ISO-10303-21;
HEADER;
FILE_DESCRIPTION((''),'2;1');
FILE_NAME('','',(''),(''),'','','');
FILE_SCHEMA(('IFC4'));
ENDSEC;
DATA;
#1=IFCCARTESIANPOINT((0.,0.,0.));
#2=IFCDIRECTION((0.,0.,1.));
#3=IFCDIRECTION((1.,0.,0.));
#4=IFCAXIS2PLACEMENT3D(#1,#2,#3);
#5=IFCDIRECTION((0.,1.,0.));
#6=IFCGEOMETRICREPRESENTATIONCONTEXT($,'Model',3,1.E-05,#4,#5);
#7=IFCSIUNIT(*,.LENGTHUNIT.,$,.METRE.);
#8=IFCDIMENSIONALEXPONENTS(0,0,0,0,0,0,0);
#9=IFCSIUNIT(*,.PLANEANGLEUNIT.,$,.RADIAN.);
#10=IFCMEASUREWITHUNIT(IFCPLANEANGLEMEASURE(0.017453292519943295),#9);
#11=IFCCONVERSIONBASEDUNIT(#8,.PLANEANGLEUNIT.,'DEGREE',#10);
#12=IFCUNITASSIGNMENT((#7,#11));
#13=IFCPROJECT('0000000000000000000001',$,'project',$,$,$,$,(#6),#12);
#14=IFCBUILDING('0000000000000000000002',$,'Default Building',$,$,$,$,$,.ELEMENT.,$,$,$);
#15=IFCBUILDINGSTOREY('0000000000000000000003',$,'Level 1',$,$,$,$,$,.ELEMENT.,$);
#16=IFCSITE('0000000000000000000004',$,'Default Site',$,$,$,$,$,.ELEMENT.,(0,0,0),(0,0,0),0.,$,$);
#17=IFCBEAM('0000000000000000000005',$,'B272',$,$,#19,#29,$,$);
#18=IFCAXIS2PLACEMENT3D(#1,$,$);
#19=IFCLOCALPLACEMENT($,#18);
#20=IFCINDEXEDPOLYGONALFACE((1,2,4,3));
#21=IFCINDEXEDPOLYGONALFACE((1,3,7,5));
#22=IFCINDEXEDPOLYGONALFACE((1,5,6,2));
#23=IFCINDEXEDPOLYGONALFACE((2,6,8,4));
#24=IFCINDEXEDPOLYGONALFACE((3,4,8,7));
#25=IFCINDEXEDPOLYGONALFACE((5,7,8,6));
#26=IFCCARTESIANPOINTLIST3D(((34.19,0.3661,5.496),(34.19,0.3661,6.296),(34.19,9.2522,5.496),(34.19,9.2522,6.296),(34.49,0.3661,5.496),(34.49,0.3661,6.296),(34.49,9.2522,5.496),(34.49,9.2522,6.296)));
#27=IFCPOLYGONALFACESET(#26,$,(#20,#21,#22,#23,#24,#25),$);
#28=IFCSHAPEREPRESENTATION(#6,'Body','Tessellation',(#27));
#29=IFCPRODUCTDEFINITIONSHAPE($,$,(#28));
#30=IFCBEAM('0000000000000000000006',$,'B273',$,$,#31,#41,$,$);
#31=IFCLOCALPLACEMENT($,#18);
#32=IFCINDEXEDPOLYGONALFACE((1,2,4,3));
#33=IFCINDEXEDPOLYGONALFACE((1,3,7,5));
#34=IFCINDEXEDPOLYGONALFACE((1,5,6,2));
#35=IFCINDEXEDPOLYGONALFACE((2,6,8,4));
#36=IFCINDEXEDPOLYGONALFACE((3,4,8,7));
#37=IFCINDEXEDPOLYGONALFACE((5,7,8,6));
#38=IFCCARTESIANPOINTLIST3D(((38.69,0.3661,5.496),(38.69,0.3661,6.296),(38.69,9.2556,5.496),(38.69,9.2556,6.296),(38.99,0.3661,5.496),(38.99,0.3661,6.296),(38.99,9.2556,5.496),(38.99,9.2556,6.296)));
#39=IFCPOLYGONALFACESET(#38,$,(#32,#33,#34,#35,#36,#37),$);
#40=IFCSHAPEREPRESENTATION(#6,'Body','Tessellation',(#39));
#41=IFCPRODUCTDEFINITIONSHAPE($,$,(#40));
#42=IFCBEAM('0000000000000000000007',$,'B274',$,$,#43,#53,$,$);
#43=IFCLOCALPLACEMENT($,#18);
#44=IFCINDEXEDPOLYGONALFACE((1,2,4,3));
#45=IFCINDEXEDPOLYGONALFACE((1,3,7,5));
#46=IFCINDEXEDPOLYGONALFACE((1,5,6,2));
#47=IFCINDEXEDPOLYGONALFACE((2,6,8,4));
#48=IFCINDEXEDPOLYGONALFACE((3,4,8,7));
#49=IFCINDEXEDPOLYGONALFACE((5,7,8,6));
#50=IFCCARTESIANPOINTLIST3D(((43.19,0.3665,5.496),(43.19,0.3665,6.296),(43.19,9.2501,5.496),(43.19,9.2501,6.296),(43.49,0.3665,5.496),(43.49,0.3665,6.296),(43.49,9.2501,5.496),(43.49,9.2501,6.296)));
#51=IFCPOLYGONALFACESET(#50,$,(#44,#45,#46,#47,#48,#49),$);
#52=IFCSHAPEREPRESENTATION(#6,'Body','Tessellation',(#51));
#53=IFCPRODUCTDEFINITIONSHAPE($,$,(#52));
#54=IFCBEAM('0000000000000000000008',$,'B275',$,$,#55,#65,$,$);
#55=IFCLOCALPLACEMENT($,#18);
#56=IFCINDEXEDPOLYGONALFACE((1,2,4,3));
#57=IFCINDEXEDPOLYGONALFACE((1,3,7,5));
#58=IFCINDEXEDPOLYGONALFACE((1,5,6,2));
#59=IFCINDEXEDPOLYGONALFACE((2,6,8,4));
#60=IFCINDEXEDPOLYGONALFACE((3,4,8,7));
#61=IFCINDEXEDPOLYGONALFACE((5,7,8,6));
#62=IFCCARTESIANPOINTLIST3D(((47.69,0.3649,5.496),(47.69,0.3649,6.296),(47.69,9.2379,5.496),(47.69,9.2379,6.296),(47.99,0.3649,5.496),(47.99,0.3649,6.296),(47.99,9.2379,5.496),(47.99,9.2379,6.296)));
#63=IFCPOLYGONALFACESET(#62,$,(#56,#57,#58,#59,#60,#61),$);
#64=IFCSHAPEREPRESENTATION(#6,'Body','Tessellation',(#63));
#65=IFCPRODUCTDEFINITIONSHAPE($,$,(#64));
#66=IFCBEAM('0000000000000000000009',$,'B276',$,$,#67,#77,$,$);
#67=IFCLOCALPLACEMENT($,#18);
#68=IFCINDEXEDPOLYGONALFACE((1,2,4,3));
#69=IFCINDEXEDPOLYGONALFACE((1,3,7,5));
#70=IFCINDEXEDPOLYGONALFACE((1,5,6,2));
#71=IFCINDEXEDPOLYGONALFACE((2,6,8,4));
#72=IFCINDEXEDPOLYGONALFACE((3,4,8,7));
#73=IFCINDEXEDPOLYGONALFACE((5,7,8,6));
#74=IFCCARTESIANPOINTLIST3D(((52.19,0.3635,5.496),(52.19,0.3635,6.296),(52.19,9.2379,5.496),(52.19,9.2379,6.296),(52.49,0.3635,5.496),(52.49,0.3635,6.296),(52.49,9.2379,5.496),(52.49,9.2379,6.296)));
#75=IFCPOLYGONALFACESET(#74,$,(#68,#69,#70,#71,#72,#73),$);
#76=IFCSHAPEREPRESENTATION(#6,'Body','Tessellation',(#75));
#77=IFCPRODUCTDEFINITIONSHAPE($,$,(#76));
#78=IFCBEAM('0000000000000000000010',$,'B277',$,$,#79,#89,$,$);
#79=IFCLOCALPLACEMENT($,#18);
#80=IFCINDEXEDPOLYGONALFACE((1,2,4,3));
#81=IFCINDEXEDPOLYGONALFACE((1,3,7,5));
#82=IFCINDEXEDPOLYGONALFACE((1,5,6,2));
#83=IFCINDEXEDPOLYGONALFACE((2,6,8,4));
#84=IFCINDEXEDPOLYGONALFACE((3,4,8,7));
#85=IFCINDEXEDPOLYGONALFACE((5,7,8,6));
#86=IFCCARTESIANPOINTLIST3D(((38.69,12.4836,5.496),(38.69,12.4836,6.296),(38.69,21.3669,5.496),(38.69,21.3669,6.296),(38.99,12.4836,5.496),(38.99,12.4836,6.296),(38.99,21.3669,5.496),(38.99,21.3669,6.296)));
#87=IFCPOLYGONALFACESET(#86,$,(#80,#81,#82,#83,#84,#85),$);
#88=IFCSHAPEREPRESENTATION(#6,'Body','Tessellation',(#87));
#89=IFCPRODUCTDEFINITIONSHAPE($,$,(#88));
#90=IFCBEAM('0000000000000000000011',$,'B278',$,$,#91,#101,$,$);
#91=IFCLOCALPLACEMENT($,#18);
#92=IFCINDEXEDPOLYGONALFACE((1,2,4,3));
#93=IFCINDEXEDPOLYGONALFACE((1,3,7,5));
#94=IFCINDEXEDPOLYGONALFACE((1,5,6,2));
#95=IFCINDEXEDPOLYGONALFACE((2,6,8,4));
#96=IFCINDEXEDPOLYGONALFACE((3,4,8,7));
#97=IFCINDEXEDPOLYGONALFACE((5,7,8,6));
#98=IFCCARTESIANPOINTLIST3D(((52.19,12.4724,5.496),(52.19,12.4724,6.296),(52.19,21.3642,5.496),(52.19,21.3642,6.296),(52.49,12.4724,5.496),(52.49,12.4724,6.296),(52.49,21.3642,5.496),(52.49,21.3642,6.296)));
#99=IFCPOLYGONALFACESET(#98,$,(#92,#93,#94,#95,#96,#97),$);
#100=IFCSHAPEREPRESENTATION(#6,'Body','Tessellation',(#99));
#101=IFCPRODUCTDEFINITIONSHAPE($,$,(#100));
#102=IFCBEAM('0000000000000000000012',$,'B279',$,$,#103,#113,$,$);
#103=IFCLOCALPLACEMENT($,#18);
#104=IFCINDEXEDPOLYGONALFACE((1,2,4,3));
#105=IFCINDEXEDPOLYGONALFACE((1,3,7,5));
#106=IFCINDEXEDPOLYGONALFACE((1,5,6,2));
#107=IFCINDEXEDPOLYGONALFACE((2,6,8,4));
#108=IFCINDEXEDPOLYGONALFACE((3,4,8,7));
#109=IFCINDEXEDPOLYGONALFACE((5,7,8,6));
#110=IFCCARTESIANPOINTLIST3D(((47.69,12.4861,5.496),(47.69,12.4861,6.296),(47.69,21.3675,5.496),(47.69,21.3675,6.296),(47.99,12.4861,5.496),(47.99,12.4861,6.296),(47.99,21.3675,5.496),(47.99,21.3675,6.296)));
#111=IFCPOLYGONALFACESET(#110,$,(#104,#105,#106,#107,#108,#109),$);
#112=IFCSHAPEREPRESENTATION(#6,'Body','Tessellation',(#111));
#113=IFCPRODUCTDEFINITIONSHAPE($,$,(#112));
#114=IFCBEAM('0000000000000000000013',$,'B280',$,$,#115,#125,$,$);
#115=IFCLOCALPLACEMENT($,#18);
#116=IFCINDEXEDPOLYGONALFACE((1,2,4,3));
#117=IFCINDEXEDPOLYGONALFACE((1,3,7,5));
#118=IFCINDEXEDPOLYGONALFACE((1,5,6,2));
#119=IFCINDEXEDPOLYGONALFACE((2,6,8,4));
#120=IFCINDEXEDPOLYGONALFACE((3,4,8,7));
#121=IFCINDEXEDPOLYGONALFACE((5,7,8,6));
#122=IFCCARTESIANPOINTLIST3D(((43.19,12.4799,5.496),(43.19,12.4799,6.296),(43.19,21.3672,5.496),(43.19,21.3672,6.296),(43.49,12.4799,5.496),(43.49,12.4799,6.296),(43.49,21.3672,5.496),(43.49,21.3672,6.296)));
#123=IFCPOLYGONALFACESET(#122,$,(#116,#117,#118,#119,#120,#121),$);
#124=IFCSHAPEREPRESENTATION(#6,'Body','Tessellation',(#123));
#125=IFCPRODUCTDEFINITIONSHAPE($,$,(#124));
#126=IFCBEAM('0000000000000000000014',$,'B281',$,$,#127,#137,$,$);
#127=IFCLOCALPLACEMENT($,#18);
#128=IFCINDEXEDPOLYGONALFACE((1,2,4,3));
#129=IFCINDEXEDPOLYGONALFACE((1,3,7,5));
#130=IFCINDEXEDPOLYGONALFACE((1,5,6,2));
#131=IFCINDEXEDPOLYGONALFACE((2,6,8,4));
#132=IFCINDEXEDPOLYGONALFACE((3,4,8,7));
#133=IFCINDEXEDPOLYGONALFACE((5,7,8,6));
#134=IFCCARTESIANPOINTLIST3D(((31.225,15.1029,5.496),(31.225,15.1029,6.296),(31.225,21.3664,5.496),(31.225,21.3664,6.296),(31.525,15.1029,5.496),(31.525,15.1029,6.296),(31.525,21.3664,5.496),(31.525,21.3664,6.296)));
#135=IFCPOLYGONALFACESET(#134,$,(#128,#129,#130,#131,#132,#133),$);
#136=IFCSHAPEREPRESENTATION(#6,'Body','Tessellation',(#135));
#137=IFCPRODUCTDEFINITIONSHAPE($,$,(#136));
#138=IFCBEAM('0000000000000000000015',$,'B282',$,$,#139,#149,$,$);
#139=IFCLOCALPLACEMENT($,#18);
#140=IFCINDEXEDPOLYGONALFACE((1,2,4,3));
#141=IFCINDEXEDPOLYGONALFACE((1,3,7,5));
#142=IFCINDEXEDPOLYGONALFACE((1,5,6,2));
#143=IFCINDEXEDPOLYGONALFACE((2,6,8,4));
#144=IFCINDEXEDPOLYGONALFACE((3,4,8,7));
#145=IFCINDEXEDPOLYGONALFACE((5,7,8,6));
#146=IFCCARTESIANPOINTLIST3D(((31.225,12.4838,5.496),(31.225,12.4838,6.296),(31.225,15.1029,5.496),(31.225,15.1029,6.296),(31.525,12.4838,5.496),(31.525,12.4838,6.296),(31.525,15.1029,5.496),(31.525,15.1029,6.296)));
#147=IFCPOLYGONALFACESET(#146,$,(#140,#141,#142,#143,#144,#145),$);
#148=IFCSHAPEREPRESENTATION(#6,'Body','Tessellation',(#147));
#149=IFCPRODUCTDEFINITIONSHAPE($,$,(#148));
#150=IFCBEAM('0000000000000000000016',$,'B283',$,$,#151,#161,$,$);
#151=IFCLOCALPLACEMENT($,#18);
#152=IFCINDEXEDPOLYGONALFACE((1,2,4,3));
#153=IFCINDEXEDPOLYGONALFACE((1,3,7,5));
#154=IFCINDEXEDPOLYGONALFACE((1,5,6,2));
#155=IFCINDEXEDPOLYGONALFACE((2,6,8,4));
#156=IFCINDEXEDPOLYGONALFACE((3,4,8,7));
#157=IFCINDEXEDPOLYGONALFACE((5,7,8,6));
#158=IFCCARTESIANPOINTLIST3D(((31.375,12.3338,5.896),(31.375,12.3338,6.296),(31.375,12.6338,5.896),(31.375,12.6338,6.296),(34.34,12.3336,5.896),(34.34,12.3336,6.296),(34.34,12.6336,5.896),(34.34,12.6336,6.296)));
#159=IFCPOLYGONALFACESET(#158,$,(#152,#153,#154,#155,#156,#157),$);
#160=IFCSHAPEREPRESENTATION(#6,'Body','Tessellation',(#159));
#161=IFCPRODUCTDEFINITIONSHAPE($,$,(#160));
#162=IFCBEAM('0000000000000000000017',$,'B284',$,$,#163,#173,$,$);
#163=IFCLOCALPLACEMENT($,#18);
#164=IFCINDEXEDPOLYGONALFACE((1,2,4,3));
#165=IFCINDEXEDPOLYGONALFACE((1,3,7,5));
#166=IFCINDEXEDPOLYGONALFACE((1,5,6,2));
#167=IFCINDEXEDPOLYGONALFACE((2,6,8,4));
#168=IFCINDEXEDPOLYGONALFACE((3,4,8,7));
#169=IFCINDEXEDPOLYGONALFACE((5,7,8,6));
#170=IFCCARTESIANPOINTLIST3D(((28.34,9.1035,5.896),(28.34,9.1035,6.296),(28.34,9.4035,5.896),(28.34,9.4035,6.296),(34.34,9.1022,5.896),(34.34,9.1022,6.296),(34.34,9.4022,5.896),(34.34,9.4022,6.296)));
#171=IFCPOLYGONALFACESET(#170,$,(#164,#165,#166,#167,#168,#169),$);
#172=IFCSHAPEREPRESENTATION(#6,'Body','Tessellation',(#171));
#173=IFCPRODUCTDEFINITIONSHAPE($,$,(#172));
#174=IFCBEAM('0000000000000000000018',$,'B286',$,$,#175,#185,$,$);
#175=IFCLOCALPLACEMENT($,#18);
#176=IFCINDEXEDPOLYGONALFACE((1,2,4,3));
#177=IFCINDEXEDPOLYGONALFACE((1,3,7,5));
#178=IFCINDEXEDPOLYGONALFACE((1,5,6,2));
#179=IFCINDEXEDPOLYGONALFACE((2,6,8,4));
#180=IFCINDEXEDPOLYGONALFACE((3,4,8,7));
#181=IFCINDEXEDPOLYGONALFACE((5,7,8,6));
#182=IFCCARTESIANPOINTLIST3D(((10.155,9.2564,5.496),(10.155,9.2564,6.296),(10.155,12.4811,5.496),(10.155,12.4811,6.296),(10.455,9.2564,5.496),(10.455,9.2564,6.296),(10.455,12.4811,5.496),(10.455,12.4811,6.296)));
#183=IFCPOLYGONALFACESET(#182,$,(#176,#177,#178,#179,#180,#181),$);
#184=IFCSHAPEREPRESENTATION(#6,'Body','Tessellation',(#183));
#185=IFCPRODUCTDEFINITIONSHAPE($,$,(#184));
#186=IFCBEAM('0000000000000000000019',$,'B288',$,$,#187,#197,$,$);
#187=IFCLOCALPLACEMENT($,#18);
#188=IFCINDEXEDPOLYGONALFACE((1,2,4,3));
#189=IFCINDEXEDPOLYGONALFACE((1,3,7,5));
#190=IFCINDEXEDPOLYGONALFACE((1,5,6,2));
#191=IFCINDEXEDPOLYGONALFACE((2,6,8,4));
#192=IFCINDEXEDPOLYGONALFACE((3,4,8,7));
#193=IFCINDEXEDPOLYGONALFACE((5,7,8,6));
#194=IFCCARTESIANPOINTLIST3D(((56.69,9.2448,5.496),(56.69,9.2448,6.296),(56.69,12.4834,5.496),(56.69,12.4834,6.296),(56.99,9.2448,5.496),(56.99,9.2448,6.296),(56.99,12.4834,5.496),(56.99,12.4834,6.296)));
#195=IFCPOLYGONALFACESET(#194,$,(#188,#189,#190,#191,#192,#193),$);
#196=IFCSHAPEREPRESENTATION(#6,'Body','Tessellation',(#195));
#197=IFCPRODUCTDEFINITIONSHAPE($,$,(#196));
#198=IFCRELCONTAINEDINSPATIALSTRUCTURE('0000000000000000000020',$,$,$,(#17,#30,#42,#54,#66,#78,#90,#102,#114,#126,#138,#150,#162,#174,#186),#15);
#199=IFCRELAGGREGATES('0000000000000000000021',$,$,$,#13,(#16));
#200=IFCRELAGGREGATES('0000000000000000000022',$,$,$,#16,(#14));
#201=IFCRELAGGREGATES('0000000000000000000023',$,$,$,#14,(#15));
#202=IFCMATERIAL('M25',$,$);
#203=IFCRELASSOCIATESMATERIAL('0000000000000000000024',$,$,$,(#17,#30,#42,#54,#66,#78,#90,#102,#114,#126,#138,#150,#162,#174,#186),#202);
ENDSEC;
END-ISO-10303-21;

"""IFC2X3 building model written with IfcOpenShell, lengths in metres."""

from ifc_helpers import new_model, entity, si_unit, converted_unit, direction, frame, frame_2d, origin_with_axes, place, context, project, spatial, rectangle, extrude, material, element, save


model = new_model("IFC2X3")

# Units and contexts
model_context = context("Model", 3, precision=1e-05, world=origin_with_axes(), true_north=direction((0.0, 1.0, 0.0)))
ifc_project = project(units=[si_unit("LENGTHUNIT", "METRE"), converted_unit("PLANEANGLEUNIT", "DEGREE", entity("IfcPlaneAngleMeasure", 0.017453292519943295), si_unit("PLANEANGLEUNIT", "RADIAN"), dimensions=[0, 0, 0, 0, 0, 0, 0])], contexts=[model_context])

# Site, building, storey
site = spatial("IfcSite", under=ifc_project, Name="Default Site", CompositionType="ELEMENT", RefLatitude=(0, 0, 0), RefLongitude=(0, 0, 0), RefElevation=0.0)
building = spatial("IfcBuilding", under=site, Name="Default Building", CompositionType="ELEMENT")
storey = spatial("IfcBuildingStorey", under=building, Name="Level 1", CompositionType="ELEMENT")

# Beams
ifc_material = material(Name="M25")
placement = place(None, origin_with_axes())
element("IfcBeam", 1, at=placement, inside=storey, material=ifc_material, Name="B272", context=model_context, shape_type="SweptSolid", body=[
    extrude(rectangle(XDim=0.3, YDim=0.8, at=frame_2d((0.0, 0.0), x_axis=(0.0, 1.0, 0.0))), frame((34.34, 0.3661, 5.896), z_axis=(0.0, 1.0, 0.0), x_axis=(0.0, 0.0, -1.0)), (0.0, 0.0, 1.0), 8.8861),
])
element("IfcBeam", 2, at=placement, inside=storey, material=ifc_material, Name="B273", context=model_context, shape_type="SweptSolid", body=[
    extrude(rectangle(XDim=0.3, YDim=0.8, at=frame_2d((0.0, 0.0), x_axis=(0.0, 1.0, 0.0))), frame((38.84, 0.3661, 5.896), z_axis=(0.0, 1.0, 0.0), x_axis=(0.0, 0.0, -1.0)), (0.0, 0.0, 1.0), 8.8895),
])
element("IfcBeam", 3, at=placement, inside=storey, material=ifc_material, Name="B274", context=model_context, shape_type="SweptSolid", body=[
    extrude(rectangle(XDim=0.3, YDim=0.8, at=frame_2d((0.0, 0.0), x_axis=(0.0, 1.0, 0.0))), frame((43.34, 0.3665, 5.896), z_axis=(0.0, 1.0, 0.0), x_axis=(0.0, 0.0, -1.0)), (0.0, 0.0, 1.0), 8.8836),
])
element("IfcBeam", 4, at=placement, inside=storey, material=ifc_material, Name="B275", context=model_context, shape_type="SweptSolid", body=[
    extrude(rectangle(XDim=0.3, YDim=0.8, at=frame_2d((0.0, 0.0), x_axis=(0.0, 1.0, 0.0))), frame((47.84, 0.3649, 5.896), z_axis=(0.0, 1.0, 0.0), x_axis=(0.0, 0.0, -1.0)), (0.0, 0.0, 1.0), 8.873),
])
element("IfcBeam", 5, at=placement, inside=storey, material=ifc_material, Name="B276", context=model_context, shape_type="SweptSolid", body=[
    extrude(rectangle(XDim=0.3, YDim=0.8, at=frame_2d((0.0, 0.0), x_axis=(0.0, 1.0, 0.0))), frame((52.34, 0.3635, 5.896), z_axis=(0.0, 1.0, 0.0), x_axis=(0.0, 0.0, -1.0)), (0.0, 0.0, 1.0), 8.8744),
])
element("IfcBeam", 6, at=placement, inside=storey, material=ifc_material, Name="B277", context=model_context, shape_type="SweptSolid", body=[
    extrude(rectangle(XDim=0.3, YDim=0.8, at=frame_2d((0.0, 0.0), x_axis=(0.0, 1.0, 0.0))), frame((38.84, 21.3669, 5.896), z_axis=(0.0, -1.0, 0.0), x_axis=(0.0, 0.0, -1.0)), (0.0, 0.0, 1.0), 8.8833),
])
element("IfcBeam", 7, at=placement, inside=storey, material=ifc_material, Name="B278", context=model_context, shape_type="SweptSolid", body=[
    extrude(rectangle(XDim=0.3, YDim=0.8, at=frame_2d((0.0, 0.0), x_axis=(0.0, 1.0, 0.0))), frame((52.34, 12.4724, 5.896), z_axis=(0.0, 1.0, 0.0), x_axis=(0.0, 0.0, -1.0)), (0.0, 0.0, 1.0), 8.8918),
])
element("IfcBeam", 8, at=placement, inside=storey, material=ifc_material, Name="B279", context=model_context, shape_type="SweptSolid", body=[
    extrude(rectangle(XDim=0.3, YDim=0.8, at=frame_2d((0.0, 0.0), x_axis=(0.0, 1.0, 0.0))), frame((47.84, 12.4861, 5.896), z_axis=(0.0, 1.0, 0.0), x_axis=(0.0, 0.0, -1.0)), (0.0, 0.0, 1.0), 8.8814),
])
element("IfcBeam", 9, at=placement, inside=storey, material=ifc_material, Name="B280", context=model_context, shape_type="SweptSolid", body=[
    extrude(rectangle(XDim=0.3, YDim=0.8, at=frame_2d((0.0, 0.0), x_axis=(0.0, 1.0, 0.0))), frame((43.34, 21.3672, 5.896), z_axis=(0.0, -1.0, 0.0), x_axis=(0.0, 0.0, -1.0)), (0.0, 0.0, 1.0), 8.8873),
])
element("IfcBeam", 10, at=placement, inside=storey, material=ifc_material, Name="B281", context=model_context, shape_type="SweptSolid", body=[
    extrude(rectangle(XDim=0.3, YDim=0.8, at=frame_2d((0.0, 0.0), x_axis=(0.0, 1.0, 0.0))), frame((31.375, 21.3664, 5.896), z_axis=(0.0, -1.0, 0.0), x_axis=(0.0, 0.0, -1.0)), (0.0, 0.0, 1.0), 6.2635),
])
element("IfcBeam", 11, at=placement, inside=storey, material=ifc_material, Name="B282", context=model_context, shape_type="SweptSolid", body=[
    extrude(rectangle(XDim=0.3, YDim=0.8, at=frame_2d((0.0, 0.0), x_axis=(0.0, 1.0, 0.0))), frame((31.375, 15.1029, 5.896), z_axis=(0.0, -1.0, 0.0), x_axis=(0.0, 0.0, -1.0)), (0.0, 0.0, 1.0), 2.6191),
])
element("IfcBeam", 12, at=placement, inside=storey, material=ifc_material, Name="B283", context=model_context, shape_type="SweptSolid", body=[
    extrude(rectangle(XDim=0.3, YDim=0.4, at=frame_2d((0.0, 0.0), x_axis=(0.0, 1.0, 0.0))), frame((31.375, 12.4838, 6.096), z_axis=(1.0, -0.000067, 0.0), x_axis=(0.0, 0.0, -1.0)), (0.0, 0.0, 1.0), 2.965),
])
element("IfcBeam", 13, at=placement, inside=storey, material=ifc_material, Name="B284", context=model_context, shape_type="SweptSolid", body=[
    extrude(rectangle(XDim=0.3, YDim=0.4, at=frame_2d((0.0, 0.0), x_axis=(0.0, 1.0, 0.0))), frame((28.34, 9.2535, 6.096), z_axis=(1.0, -0.000213, 0.0), x_axis=(0.0, 0.0, -1.0)), (0.0, 0.0, 1.0), 6.0),
])
element("IfcBeam", 14, at=placement, inside=storey, material=ifc_material, Name="B286", context=model_context, shape_type="SweptSolid", body=[
    extrude(rectangle(XDim=0.3, YDim=0.8, at=frame_2d((0.0, 0.0), x_axis=(0.0, 1.0, 0.0))), frame((10.305, 12.4811, 5.896), z_axis=(0.0, -1.0, 0.0), x_axis=(0.0, 0.0, -1.0)), (0.0, 0.0, 1.0), 3.2247),
])
element("IfcBeam", 15, at=placement, inside=storey, material=ifc_material, Name="B288", context=model_context, shape_type="SweptSolid", body=[
    extrude(rectangle(XDim=0.3, YDim=0.8, at=frame_2d((0.0, 0.0), x_axis=(0.0, 1.0, 0.0))), frame((56.84, 12.4834, 5.896), z_axis=(0.0, -1.0, 0.0), x_axis=(0.0, 0.0, -1.0)), (0.0, 0.0, 1.0), 3.2386),
])

save(model, "model.ifc")
